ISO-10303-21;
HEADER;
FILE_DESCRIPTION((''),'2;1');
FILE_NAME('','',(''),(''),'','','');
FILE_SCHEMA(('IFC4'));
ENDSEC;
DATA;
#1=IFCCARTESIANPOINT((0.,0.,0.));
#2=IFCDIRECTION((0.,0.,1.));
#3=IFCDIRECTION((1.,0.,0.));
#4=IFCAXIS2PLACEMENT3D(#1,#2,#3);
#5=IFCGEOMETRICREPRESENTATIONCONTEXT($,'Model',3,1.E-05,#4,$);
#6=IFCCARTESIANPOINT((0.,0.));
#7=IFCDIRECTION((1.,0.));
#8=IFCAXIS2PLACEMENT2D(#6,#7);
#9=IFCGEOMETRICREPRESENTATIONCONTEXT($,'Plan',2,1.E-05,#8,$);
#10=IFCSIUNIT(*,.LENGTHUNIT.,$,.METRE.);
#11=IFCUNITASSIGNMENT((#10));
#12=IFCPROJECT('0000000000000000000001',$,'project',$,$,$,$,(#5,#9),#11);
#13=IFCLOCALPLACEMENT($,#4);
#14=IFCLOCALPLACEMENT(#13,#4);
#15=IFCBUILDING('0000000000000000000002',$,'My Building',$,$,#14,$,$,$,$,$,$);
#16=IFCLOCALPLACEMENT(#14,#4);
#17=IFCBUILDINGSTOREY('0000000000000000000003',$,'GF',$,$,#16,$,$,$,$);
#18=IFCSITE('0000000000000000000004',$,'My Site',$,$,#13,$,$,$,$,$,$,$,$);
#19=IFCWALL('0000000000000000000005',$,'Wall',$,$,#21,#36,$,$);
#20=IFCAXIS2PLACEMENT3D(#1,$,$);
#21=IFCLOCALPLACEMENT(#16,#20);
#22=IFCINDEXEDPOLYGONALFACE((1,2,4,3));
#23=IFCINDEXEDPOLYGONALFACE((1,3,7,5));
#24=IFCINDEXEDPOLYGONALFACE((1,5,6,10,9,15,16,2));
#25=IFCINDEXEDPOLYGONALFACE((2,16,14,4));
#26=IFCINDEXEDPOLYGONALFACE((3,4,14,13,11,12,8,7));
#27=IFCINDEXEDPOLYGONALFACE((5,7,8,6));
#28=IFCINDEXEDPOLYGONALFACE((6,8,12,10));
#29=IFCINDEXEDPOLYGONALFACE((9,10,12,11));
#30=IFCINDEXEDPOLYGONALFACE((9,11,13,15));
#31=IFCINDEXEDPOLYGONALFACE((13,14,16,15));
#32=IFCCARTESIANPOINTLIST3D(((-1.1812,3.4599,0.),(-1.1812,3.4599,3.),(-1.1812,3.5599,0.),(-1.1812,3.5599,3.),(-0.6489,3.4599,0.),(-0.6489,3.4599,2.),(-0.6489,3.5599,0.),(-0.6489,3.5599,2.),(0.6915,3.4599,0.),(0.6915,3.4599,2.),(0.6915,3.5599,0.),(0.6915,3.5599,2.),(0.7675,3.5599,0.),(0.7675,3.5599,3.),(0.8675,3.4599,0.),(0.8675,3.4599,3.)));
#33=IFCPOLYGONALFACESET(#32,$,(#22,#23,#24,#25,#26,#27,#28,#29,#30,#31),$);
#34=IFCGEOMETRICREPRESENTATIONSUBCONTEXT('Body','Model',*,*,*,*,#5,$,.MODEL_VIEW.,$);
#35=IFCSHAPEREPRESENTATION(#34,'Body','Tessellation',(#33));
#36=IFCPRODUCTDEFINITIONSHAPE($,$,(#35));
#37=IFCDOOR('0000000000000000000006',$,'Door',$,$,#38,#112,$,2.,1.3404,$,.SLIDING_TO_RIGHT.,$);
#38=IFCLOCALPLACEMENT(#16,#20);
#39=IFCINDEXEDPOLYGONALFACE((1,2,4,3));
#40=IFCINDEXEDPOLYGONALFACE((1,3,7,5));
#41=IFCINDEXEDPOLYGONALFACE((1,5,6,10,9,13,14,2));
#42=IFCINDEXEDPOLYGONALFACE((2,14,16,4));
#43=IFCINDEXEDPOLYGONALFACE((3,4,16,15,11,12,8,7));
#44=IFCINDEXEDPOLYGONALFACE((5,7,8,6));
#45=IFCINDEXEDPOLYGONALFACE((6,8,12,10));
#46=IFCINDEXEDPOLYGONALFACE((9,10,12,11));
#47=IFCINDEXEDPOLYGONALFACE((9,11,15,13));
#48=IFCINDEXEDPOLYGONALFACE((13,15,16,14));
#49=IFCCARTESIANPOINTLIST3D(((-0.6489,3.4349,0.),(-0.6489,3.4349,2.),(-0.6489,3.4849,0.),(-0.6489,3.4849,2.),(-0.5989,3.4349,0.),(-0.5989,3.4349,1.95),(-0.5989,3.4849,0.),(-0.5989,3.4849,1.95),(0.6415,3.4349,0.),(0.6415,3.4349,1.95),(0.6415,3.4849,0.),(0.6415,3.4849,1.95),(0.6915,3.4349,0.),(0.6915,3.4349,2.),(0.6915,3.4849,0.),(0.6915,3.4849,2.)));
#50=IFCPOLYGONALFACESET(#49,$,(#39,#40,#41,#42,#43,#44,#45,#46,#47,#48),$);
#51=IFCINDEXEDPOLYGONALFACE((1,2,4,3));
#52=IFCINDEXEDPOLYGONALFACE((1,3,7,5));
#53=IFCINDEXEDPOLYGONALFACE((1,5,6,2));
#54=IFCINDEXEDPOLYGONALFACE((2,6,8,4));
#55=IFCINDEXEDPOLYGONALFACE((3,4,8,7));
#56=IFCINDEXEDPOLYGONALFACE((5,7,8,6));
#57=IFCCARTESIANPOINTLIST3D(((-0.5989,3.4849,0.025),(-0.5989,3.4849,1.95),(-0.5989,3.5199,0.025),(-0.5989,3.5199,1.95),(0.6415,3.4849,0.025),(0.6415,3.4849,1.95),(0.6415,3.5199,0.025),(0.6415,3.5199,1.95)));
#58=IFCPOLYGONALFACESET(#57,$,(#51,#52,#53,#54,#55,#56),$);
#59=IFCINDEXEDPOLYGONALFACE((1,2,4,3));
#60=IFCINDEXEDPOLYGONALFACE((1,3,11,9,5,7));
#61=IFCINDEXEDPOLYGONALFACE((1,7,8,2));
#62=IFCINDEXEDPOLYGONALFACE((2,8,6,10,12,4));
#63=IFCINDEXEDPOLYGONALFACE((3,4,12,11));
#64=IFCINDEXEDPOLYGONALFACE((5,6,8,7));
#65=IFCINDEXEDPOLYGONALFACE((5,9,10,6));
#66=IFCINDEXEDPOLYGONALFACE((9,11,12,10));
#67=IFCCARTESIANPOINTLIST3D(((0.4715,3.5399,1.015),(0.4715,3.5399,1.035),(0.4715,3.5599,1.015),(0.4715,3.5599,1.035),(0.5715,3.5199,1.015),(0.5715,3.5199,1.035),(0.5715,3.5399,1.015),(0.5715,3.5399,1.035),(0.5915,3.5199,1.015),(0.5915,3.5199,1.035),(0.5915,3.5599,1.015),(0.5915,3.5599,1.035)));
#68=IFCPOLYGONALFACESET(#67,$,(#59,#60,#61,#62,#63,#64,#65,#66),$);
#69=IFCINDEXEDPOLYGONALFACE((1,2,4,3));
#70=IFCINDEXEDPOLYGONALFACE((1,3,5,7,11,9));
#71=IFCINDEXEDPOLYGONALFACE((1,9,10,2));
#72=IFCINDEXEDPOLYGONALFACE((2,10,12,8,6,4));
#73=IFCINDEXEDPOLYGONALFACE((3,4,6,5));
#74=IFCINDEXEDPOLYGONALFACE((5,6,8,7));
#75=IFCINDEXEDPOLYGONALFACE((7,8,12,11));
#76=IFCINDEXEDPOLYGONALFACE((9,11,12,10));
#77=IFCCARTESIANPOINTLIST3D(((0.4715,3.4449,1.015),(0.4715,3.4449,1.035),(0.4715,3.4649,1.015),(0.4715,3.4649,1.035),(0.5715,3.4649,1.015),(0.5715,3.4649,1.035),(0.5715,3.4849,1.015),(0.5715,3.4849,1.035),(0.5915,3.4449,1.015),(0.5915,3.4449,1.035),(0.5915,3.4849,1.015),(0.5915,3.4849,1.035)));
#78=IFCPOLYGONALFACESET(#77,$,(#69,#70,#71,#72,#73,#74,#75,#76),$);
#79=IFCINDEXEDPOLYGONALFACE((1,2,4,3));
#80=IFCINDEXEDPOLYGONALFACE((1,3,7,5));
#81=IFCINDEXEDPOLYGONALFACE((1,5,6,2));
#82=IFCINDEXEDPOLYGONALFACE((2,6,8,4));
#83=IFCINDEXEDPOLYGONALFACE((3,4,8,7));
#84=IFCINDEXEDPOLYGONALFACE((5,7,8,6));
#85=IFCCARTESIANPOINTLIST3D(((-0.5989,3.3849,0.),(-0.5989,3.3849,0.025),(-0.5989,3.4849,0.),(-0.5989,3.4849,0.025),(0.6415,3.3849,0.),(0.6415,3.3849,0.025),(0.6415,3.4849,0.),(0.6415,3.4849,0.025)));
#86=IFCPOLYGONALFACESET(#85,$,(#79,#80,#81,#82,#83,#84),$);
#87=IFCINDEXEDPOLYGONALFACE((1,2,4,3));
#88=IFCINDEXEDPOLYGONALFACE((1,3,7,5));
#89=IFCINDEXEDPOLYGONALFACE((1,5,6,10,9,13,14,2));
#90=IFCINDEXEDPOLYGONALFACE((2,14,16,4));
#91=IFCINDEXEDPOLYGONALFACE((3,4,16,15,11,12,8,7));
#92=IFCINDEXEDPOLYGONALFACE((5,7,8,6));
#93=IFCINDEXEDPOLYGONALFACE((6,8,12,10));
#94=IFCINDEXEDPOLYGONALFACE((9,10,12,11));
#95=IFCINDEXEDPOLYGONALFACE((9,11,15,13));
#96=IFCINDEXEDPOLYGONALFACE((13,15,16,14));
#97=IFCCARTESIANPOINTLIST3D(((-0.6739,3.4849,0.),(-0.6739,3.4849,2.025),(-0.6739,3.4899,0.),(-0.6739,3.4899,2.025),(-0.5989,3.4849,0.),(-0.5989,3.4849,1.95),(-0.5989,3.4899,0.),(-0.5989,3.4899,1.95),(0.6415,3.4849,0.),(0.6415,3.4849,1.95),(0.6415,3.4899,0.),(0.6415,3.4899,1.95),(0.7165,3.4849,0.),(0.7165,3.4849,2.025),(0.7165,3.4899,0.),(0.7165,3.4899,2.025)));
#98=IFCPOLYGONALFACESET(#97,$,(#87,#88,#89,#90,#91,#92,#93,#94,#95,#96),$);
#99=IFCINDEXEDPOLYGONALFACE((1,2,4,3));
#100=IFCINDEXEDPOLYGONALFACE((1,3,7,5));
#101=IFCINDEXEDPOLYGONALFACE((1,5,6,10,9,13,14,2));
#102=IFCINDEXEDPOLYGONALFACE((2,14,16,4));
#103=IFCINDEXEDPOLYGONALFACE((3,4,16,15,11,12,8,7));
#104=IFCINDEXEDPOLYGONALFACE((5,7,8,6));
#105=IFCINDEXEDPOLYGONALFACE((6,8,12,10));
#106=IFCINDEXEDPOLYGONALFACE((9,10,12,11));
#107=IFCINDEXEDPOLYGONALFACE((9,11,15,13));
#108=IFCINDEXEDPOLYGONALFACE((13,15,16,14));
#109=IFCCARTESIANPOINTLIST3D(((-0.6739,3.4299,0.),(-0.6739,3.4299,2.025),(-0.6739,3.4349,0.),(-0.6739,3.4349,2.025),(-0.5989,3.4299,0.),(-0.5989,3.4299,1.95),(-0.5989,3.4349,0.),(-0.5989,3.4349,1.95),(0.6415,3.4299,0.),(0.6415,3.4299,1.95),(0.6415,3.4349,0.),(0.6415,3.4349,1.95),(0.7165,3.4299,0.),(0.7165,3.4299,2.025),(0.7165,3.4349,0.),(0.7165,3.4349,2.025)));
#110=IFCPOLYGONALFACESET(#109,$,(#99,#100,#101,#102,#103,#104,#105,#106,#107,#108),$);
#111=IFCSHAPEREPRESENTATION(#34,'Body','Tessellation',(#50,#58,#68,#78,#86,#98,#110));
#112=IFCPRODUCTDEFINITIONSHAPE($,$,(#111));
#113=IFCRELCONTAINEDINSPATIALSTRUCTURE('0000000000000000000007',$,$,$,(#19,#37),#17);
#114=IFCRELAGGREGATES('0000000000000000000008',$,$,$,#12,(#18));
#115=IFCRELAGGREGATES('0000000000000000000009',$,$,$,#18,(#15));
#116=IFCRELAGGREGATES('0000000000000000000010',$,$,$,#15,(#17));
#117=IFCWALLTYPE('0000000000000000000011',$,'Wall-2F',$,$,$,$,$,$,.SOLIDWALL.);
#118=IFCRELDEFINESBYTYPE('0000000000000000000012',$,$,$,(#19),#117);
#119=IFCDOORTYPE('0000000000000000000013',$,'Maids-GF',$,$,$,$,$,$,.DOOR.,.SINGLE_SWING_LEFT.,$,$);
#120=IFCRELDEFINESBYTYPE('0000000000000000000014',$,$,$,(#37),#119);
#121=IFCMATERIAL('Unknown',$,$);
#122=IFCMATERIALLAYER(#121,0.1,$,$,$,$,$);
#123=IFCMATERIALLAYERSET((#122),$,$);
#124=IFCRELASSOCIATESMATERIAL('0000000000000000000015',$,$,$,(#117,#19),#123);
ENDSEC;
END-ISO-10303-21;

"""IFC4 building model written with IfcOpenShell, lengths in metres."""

from ifc_helpers import new_model, entity, si_unit, frame, origin_with_axes, origin_2d_with_axis, place, context, subcontext, project, spatial, line, indexed_curve, outline, extrude, shape, source, transform, mapped, material, layer, layer_set, layer_usage, type_object, type_shapes, element, fill, save


model = new_model("IFC4")

# Units and contexts
model_context = context("Model", 3, precision=1e-05, world=origin_with_axes())
plan_context = context("Plan", 2, precision=1e-05, world=origin_2d_with_axis())
body_context_1 = subcontext(model_context, "Body", "Model", "MODEL_VIEW")
body_context_2 = subcontext(plan_context, "Body", "Plan", "PLAN_VIEW")
ifc_project = project(units=[si_unit("LENGTHUNIT", "METRE")], contexts=[model_context, plan_context])

# Site, building, storey
site_placement = place(None, origin_with_axes())
site = spatial("IfcSite", under=ifc_project, at=site_placement, Name="My Site")
building_placement = place(site_placement, origin_with_axes())
building = spatial("IfcBuilding", under=site, at=building_placement, Name="My Building")
storey_placement = place(building_placement, origin_with_axes())
storey = spatial("IfcBuildingStorey", under=building, at=storey_placement, Name="GF")

# Shared definitions
ifc_material = material(Name="Unknown")

# Shared definitions
ifc_layer_1 = layer(ifc_material, 0.1)
ifc_layer_set_1 = layer_set([ifc_layer_1])
wall_type = type_object("IfcWallType", Name="Wall-2F", PredefinedType="SOLIDWALL", material=ifc_layer_set_1)

# Wall, opening, door
ifc_layer_usage_1 = layer_usage(ifc_layer_set_1, "AXIS2", "POSITIVE", 0.0)
wall_1_placement = place(storey_placement, frame((0.7675, 3.5599, 0.0), z_axis=(0.0, 0.0, 1.0), x_axis=(-1.0, 0.0, 0.0)))
wall_1 = element("IfcWall", 1, at=wall_1_placement, inside=storey, type_object=wall_type, material=ifc_layer_usage_1, Name="Wall", context=body_context_1, shape_type="SweptSolid", body=[
    extrude(outline(indexed_curve([(0.0, 0.0), (-0.1, 0.1), (1.9486, 0.1), (1.9486, 0.0)], segments=[line(1, 2, 3, 4, 1)])), origin_with_axes(), (0.0, 0.0, 1.0), 3.0),
])
shared_shape_1 = source(origin_with_axes(), body_context_1, "Body", "SweptSolid", [
    extrude(outline(indexed_curve([(0.0, 0.0), (1.3404, 0.0), (1.3404, 2.0), (0.0, 2.0)], segments=[line(1, 2, 3, 4, 1)])), frame((0.0, -0.6, 0.0), z_axis=(0.0, -1.0, 0.0), x_axis=(1.0, 0.0, 0.0)), (0.0, 0.0, -1.0), 1.2),
])
opening_1_placement = place(wall_1_placement, frame((0.076, 0.075, 0.0), z_axis=(0.0, 0.0, 1.0), x_axis=(1.0, -0.000001, 0.0)))
opening_1 = element("IfcOpeningElement", 2, at=opening_1_placement, cuts=wall_1, PredefinedType="OPENING", context=body_context_1, shape_type="MappedRepresentation", body=[
    mapped(shared_shape_1, transform((0.0, 0.0, 0.0), x_axis=(1.0, 0.0, 0.0), y_axis=(0.0, 1.0, 0.0), z_axis=(0.0, 0.0, 1.0), scale=1.0)),
])
door_type_1 = type_object("IfcDoorType", Name="Maids-GF", OperationType="SINGLE_SWING_LEFT", PredefinedType="DOOR")
shared_shape_2 = source(origin_with_axes(), body_context_1, "Body", "SweptSolid", [
    extrude(outline(indexed_curve([(0.0, 0.0), (0.0, 2.0), (1.3404, 2.0), (1.3404, 0.0), (1.2904, 0.0), (1.2904, 1.95), (0.05, 1.95), (0.05, 0.0)], segments=[line(1, 2, 3, 4, 5, 6, 7, 8, 1)])), frame((0.0, 0.0, 0.0), z_axis=(0.0, -1.0, 0.0), x_axis=(1.0, 0.0, 0.0)), (0.0, 0.0, -1.0), 0.05),
    extrude(outline(indexed_curve([(0.0, 0.0), (1.2404, 0.0), (1.2404, 0.035), (0.0, 0.035)], segments=[line(1, 2, 3, 4, 1)])), frame((0.05, -0.035, 0.025), z_axis=(0.0, 0.0, 1.0), x_axis=(1.0, 0.0, 0.0)), (0.0, 0.0, 1.0), 1.925),
    extrude(outline(indexed_curve([(0.0, 0.0), (0.0, -0.04), (0.12, -0.04), (0.12, -0.02), (0.02, -0.02), (0.02, 0.0)], segments=[line(1, 2, 3, 4, 5, 6, 1)])), frame((0.1, -0.035, 1.015), z_axis=(0.0, 0.0, 1.0), x_axis=(1.0, 0.0, 0.0)), (0.0, 0.0, 1.0), 0.02),
    extrude(outline(indexed_curve([(0.0, 0.0), (0.0, 0.04), (0.12, 0.04), (0.12, 0.02), (0.02, 0.02), (0.02, 0.0)], segments=[line(1, 2, 3, 4, 5, 6, 1)])), frame((0.1, 0.0, 1.015), z_axis=(0.0, 0.0, 1.0), x_axis=(1.0, 0.0, 0.0)), (0.0, 0.0, 1.0), 0.02),
    extrude(outline(indexed_curve([(0.0, 0.0), (1.2404, 0.0), (1.2404, 0.1), (0.0, 0.1)], segments=[line(1, 2, 3, 4, 1)])), frame((0.05, 0.0, 0.0), z_axis=(0.0, 0.0, 1.0), x_axis=(1.0, 0.0, 0.0)), (0.0, 0.0, 1.0), 0.025),
    extrude(outline(indexed_curve([(0.0, 0.0), (0.0, 2.025), (1.3904, 2.025), (1.3904, 0.0), (1.3154, 0.0), (1.3154, 1.95), (0.075, 1.95), (0.075, 0.0)], segments=[line(1, 2, 3, 4, 5, 6, 7, 8, 1)])), frame((-0.025, -0.005, 0.0), z_axis=(0.0, -1.0, 0.0), x_axis=(1.0, 0.0, 0.0)), (0.0, 0.0, -1.0), 0.005),
    extrude(outline(indexed_curve([(0.0, 0.0), (0.0, 2.025), (1.3904, 2.025), (1.3904, 0.0), (1.3154, 0.0), (1.3154, 1.95), (0.075, 1.95), (0.075, 0.0)], segments=[line(1, 2, 3, 4, 5, 6, 7, 8, 1)])), frame((-0.025, 0.05, 0.0), z_axis=(0.0, -1.0, 0.0), x_axis=(1.0, 0.0, 0.0)), (0.0, 0.0, -1.0), 0.005),
])
shared_shape_3 = source(origin_with_axes(), body_context_2, "Body", "Curve2D", [
    entity("IfcIndexedPolyCurve", entity("IfcCartesianPointList2D", [[0.0, 0.0], [0.05, 0.0], [0.05, 0.05], [0.0, 0.05]]), [entity("IfcLineIndex", [1, 2, 3, 4, 1])]),
    entity("IfcIndexedPolyCurve", entity("IfcCartesianPointList2D", [[1.3404, 0.0], [1.2904, 0.0], [1.2904, 0.05], [1.3404, 0.05]]), [entity("IfcLineIndex", [1, 2, 3, 4, 1])]),
    entity("IfcIndexedPolyCurve", entity("IfcCartesianPointList2D", [[1.9106, -0.035], [0.6702, -0.035], [0.6702, 0.0], [1.9106, 0.0]]), [entity("IfcLineIndex", [1, 2, 3, 4, 1])]),
])
type_shapes(door_type_1, [shared_shape_2, shared_shape_3])
door_1_placement = place(opening_1_placement, frame((0.0, 0.0, 0.0), z_axis=(0.0, 0.0, 1.0), x_axis=(1.0, 0.0, 0.0)))
door_1 = element("IfcDoor", 3, at=door_1_placement, inside=storey, type_object=door_type_1, Name="Door", OperationType="SLIDING_TO_RIGHT", OverallHeight=2.0, OverallWidth=1.3404, shapes=[
    shape(body_context_1, "Body", "MappedRepresentation", [mapped(shared_shape_2, transform((0.0, 0.0, 0.0), x_axis=(1.0, 0.0, 0.0), y_axis=(0.0, 1.0, 0.0), z_axis=(0.0, 0.0, 1.0), scale=1.0))]),
    shape(body_context_2, "Body", "MappedRepresentation", [mapped(shared_shape_3, transform((0.0, 0.0, 0.0), x_axis=(1.0, 0.0, 0.0), y_axis=(0.0, 1.0, 0.0), z_axis=(0.0, 0.0, 1.0), scale=1.0))]),
])
fill(opening_1, door_1)

save(model, "model.ifc")
